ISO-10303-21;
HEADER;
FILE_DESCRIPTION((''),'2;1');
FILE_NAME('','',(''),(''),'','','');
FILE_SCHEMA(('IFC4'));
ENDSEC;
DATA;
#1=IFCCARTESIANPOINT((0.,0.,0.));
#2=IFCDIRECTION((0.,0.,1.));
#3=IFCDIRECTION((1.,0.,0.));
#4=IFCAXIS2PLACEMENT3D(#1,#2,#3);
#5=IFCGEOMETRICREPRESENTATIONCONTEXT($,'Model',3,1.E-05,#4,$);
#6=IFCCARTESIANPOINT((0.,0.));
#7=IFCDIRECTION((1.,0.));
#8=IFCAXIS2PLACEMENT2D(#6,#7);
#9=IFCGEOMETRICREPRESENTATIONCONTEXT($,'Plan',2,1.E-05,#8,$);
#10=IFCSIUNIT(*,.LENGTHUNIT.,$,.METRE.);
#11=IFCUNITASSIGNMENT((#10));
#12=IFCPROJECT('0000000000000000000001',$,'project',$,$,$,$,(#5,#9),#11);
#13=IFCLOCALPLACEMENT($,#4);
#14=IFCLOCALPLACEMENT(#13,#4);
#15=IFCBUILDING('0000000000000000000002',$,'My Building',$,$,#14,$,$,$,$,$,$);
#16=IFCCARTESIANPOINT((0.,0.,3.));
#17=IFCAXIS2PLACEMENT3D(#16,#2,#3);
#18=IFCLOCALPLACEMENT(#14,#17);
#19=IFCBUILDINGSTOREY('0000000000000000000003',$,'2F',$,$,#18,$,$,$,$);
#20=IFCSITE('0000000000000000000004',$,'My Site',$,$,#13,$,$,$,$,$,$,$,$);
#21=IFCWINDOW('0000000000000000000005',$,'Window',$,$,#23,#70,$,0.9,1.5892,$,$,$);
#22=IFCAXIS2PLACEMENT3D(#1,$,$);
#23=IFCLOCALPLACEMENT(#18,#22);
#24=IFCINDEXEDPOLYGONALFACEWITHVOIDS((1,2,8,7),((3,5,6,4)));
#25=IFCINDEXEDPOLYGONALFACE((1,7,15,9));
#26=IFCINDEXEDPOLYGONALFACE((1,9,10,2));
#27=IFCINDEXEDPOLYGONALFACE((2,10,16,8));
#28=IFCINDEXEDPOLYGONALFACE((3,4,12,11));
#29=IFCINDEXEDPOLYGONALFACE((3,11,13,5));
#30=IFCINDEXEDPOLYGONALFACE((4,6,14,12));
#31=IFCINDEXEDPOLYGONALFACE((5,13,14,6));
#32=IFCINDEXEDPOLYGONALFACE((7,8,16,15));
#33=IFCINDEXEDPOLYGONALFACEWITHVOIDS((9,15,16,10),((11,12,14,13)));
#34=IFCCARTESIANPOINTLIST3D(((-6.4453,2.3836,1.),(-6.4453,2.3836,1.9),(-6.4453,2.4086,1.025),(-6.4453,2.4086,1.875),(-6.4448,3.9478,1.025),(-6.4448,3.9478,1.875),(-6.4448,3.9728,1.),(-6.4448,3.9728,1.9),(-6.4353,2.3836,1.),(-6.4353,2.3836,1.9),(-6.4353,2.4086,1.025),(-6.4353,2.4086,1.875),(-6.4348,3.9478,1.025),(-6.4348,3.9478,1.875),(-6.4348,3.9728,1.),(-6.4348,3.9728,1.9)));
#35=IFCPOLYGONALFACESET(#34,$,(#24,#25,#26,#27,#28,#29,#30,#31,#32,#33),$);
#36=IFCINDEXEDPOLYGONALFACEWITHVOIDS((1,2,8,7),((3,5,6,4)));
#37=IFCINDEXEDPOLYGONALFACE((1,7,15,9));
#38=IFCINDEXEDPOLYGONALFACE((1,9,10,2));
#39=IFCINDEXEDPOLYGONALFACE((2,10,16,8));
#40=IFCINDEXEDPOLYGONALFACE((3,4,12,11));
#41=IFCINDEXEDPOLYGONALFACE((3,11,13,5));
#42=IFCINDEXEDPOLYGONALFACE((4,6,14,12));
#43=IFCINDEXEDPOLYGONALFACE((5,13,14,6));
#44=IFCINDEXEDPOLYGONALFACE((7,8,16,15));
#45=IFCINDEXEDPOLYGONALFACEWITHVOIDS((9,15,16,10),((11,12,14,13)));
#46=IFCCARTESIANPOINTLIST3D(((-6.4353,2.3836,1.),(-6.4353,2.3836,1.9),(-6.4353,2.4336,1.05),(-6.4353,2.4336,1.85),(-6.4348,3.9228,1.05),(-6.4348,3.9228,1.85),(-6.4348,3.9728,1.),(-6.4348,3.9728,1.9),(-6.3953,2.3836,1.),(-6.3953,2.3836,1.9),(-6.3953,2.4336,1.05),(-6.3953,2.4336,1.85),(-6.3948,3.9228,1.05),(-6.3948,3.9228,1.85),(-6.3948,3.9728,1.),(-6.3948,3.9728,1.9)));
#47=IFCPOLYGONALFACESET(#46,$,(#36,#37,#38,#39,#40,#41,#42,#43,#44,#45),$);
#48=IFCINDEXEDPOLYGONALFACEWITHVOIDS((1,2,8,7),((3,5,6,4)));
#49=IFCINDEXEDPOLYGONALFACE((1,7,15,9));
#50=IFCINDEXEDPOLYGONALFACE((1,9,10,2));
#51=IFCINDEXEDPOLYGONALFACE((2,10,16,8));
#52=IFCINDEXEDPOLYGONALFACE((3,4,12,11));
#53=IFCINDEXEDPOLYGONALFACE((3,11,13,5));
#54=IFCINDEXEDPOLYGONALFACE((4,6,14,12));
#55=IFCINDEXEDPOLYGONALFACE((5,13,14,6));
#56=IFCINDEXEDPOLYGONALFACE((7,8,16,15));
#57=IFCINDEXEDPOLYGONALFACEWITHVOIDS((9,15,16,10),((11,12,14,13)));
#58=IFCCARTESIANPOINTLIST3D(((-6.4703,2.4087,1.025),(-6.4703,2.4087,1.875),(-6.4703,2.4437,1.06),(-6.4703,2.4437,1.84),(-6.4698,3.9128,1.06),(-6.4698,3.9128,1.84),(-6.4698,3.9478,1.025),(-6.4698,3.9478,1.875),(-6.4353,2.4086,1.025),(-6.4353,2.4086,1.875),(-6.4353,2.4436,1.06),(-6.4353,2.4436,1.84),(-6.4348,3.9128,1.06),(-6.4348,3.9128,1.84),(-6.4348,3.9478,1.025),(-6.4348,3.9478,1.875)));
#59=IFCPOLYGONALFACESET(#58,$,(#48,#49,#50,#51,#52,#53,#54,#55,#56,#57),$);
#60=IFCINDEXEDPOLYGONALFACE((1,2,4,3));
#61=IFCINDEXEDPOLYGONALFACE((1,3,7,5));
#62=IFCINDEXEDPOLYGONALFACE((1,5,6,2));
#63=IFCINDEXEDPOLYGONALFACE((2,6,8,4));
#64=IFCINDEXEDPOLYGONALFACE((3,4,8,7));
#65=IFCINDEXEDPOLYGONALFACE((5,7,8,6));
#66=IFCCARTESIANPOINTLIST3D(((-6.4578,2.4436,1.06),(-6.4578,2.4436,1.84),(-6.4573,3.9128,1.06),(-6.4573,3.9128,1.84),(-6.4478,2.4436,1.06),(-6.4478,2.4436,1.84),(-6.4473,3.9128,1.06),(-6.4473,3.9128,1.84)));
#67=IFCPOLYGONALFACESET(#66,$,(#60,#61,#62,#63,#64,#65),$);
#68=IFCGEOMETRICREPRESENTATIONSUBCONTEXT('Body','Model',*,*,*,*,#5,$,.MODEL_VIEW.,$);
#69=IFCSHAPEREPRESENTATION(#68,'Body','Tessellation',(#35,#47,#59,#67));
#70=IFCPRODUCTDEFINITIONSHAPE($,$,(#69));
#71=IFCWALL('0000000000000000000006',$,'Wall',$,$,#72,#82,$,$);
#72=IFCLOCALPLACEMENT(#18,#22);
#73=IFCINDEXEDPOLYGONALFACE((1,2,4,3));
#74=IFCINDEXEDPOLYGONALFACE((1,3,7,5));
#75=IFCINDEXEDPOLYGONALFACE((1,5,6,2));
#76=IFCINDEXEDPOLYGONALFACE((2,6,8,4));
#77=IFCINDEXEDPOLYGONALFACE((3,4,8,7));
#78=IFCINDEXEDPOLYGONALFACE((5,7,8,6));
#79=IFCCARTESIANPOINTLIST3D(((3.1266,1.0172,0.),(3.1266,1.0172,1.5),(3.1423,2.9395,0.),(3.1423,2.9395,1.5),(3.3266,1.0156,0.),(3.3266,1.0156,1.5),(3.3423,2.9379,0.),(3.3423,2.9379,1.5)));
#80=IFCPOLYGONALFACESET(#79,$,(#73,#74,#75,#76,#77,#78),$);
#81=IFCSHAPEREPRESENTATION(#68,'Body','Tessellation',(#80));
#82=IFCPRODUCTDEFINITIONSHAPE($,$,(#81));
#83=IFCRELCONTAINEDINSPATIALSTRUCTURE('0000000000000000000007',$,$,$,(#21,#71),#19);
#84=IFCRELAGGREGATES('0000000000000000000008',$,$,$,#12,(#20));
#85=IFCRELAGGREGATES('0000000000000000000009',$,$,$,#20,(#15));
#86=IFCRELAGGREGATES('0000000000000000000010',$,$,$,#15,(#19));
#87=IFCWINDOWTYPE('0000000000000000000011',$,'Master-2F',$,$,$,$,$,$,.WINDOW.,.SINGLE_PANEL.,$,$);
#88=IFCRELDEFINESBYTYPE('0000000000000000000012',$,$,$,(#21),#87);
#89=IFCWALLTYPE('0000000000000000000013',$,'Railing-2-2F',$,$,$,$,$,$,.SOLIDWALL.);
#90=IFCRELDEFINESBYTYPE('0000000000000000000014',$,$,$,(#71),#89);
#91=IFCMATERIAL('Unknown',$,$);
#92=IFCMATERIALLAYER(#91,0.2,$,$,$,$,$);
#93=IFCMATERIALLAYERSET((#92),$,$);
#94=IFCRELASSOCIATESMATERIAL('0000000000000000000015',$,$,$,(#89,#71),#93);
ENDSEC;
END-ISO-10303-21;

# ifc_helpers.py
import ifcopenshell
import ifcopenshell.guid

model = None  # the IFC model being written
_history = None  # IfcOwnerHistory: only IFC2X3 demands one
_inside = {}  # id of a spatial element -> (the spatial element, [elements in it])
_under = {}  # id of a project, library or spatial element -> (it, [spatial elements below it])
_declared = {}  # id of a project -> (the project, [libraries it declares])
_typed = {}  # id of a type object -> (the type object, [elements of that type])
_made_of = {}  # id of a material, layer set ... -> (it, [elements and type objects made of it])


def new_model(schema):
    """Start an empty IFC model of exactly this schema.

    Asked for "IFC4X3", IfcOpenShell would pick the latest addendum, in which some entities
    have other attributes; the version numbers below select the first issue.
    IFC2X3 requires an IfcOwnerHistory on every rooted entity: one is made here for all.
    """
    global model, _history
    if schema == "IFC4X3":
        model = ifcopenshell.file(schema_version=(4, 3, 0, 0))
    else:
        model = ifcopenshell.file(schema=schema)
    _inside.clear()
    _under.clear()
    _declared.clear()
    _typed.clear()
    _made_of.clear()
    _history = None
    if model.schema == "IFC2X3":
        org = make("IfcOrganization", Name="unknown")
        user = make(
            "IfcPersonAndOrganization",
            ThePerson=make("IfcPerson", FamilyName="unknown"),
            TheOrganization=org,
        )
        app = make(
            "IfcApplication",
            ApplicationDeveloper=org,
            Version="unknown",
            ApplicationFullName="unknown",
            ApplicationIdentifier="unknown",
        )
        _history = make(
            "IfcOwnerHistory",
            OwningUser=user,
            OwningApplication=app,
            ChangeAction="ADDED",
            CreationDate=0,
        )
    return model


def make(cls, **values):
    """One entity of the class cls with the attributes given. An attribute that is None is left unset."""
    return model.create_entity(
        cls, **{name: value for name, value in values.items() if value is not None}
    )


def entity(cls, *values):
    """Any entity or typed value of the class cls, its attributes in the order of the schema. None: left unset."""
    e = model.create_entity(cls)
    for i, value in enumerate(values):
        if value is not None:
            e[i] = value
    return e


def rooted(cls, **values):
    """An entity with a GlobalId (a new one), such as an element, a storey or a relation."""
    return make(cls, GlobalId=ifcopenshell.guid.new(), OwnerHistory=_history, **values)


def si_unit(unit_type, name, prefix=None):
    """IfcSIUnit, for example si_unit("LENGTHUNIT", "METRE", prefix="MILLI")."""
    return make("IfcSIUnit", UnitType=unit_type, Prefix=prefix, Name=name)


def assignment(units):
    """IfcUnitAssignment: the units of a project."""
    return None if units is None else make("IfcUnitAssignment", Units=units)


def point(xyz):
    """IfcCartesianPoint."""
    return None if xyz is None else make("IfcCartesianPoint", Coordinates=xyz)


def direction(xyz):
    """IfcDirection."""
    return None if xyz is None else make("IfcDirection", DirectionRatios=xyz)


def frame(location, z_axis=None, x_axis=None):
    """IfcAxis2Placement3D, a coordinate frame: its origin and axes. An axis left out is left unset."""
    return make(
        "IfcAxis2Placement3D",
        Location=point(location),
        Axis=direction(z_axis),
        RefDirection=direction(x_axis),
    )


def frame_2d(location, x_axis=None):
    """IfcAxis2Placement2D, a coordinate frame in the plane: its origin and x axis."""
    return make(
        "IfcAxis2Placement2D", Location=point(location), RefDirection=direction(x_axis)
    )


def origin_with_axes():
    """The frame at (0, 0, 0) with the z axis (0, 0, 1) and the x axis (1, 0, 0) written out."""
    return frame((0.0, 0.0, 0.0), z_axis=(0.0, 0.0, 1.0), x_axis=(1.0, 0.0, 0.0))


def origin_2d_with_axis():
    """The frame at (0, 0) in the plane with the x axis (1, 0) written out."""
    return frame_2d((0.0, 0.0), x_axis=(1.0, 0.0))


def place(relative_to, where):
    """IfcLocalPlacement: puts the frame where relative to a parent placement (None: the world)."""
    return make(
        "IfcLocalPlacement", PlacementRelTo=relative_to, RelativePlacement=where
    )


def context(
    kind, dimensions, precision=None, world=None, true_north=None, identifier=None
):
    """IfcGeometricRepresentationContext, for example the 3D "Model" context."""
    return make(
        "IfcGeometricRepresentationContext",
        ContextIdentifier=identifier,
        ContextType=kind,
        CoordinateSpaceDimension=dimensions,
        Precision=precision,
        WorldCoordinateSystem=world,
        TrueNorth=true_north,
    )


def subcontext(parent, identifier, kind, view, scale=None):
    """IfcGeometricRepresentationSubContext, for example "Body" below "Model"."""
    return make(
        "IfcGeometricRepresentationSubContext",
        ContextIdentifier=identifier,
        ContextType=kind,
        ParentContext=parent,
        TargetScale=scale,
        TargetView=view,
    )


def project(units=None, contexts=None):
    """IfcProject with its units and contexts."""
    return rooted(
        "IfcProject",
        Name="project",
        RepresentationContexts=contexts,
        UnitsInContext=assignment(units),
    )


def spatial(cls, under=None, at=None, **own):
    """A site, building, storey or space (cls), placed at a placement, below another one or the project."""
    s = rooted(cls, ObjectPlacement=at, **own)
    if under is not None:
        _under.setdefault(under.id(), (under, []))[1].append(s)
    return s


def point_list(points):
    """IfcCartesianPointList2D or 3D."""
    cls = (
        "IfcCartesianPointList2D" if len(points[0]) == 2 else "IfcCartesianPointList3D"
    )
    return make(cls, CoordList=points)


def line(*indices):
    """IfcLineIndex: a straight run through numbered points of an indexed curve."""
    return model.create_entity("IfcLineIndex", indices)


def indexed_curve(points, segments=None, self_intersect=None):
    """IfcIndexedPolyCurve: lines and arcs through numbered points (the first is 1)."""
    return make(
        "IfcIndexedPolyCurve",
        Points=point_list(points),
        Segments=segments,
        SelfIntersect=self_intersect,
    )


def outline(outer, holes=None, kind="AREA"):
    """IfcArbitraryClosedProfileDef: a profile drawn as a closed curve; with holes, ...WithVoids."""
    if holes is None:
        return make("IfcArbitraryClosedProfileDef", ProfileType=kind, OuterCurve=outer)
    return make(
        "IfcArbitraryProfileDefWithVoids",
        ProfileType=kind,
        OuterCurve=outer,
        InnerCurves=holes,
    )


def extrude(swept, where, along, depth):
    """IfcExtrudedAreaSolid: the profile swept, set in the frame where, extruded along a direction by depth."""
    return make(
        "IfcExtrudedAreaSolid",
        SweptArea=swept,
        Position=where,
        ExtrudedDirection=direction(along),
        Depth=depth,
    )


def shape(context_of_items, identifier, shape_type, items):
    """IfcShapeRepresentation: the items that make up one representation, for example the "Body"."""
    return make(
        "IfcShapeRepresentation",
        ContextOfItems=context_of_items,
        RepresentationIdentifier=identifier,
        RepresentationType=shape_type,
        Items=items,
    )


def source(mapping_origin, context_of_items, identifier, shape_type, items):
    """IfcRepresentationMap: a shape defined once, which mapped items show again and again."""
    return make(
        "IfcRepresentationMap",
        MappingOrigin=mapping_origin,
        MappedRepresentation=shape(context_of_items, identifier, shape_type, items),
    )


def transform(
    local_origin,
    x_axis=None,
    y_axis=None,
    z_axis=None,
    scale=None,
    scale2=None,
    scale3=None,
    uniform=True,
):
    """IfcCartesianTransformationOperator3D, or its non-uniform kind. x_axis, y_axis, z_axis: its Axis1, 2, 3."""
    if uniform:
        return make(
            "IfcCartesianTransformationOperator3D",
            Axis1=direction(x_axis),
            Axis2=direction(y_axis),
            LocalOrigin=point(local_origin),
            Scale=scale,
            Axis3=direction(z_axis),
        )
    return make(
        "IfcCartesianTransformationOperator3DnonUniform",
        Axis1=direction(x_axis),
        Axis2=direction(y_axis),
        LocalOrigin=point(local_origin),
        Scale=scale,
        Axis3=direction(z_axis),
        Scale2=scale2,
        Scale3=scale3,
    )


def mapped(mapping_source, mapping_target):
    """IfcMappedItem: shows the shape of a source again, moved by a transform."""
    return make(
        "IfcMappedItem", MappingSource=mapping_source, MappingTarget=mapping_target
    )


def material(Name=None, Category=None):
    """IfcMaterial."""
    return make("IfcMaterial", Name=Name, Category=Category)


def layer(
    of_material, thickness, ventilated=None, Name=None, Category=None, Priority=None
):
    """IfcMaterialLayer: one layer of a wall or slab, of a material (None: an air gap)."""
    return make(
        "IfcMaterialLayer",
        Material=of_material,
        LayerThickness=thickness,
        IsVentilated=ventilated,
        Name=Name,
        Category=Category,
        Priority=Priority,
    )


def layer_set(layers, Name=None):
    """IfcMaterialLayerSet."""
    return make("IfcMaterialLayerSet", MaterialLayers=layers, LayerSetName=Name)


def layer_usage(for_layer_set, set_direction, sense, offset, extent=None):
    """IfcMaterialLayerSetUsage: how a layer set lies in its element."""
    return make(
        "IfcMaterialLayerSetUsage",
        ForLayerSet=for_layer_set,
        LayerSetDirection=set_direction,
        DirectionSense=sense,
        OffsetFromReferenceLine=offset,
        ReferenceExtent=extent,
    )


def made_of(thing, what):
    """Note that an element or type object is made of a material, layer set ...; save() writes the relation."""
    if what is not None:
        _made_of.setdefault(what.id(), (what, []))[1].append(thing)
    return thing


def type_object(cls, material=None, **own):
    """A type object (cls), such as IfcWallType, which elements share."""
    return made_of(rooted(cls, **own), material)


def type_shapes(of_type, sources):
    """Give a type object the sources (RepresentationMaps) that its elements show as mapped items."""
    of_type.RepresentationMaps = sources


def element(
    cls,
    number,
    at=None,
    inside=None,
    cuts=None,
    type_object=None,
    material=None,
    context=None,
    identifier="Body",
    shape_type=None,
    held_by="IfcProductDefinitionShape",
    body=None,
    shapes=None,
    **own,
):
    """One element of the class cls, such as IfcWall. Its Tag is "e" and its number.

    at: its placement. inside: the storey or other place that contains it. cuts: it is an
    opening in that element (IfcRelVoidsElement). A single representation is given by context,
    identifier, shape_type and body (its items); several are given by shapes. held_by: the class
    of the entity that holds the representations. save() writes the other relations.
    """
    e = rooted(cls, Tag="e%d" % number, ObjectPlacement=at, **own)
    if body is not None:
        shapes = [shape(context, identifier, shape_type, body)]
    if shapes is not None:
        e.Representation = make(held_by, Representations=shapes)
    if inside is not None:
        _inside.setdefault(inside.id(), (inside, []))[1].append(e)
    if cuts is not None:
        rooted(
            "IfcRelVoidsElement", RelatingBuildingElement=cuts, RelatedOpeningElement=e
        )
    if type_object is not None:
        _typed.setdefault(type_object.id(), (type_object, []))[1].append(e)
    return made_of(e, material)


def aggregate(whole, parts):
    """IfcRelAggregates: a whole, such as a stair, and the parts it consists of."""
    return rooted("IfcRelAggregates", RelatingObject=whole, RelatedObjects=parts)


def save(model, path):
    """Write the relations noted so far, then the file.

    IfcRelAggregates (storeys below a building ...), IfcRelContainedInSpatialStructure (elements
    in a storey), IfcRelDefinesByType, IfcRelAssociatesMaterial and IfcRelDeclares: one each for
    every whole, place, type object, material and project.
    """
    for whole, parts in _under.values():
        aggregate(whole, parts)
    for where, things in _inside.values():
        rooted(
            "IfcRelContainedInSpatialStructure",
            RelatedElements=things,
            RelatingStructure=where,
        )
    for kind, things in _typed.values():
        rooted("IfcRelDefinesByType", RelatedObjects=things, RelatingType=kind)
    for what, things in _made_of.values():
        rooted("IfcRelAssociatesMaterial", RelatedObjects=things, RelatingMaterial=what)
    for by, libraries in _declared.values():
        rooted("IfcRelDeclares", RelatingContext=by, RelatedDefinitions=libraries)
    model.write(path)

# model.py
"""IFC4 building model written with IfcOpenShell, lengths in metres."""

from ifc_helpers import new_model, entity, si_unit, frame, origin_with_axes, origin_2d_with_axis, place, context, subcontext, project, spatial, line, indexed_curve, outline, extrude, shape, source, transform, mapped, material, layer, layer_set, layer_usage, type_object, type_shapes, element, save


model = new_model("IFC4")

# Units and contexts
model_context = context("Model", 3, precision=1e-05, world=origin_with_axes())
plan_context = context("Plan", 2, precision=1e-05, world=origin_2d_with_axis())
body_context_1 = subcontext(model_context, "Body", "Model", "MODEL_VIEW")
body_context_2 = subcontext(plan_context, "Body", "Plan", "PLAN_VIEW")
ifc_project = project(units=[si_unit("LENGTHUNIT", "METRE")], contexts=[model_context, plan_context])

# Site, building, storey
site_placement = place(None, origin_with_axes())
site = spatial("IfcSite", under=ifc_project, at=site_placement, Name="My Site")
building_placement = place(site_placement, origin_with_axes())
building = spatial("IfcBuilding", under=site, at=building_placement, Name="My Building")
storey_placement = place(building_placement, frame((0.0, 0.0, 3.0), z_axis=(0.0, 0.0, 1.0), x_axis=(1.0, 0.0, 0.0)))
storey = spatial("IfcBuildingStorey", under=building, at=storey_placement, Name="2F")

# Shared definitions
ifc_material = material(Name="Unknown")

# Window
window_type_1 = type_object("IfcWindowType", Name="Master-2F", PartitioningType="SINGLE_PANEL", PredefinedType="WINDOW")
shared_shape_1 = source(origin_with_axes(), body_context_1, "Body", "SweptSolid", [
    extrude(outline(indexed_curve([(0.0, 0.0), (1.5892, 0.0), (1.5892, 0.9), (0.0, 0.9)], segments=[line(1, 2, 3, 4, 1)]), holes=[indexed_curve([(0.025, 0.025), (1.5642, 0.025), (1.5642, 0.875), (0.025, 0.875)], segments=[line(1, 2, 3, 4, 1)])]), frame((0.0, 0.09, 0.0), z_axis=(0.0, -1.0, 0.0), x_axis=(1.0, 0.0, 0.0)), (0.0, 0.0, -1.0), 0.01),
    extrude(outline(indexed_curve([(0.0, 0.0), (1.5892, 0.0), (1.5892, 0.9), (0.0, 0.9)], segments=[line(1, 2, 3, 4, 1)]), holes=[indexed_curve([(0.05, 0.05), (1.5392, 0.05), (1.5392, 0.85), (0.05, 0.85)], segments=[line(1, 2, 3, 4, 1)])]), frame((0.0, 0.05, 0.0), z_axis=(0.0, -1.0, 0.0), x_axis=(1.0, 0.0, 0.0)), (0.0, 0.0, -1.0), 0.04),
    extrude(outline(indexed_curve([(0.0, 0.0), (1.5392, 0.0), (1.5392, 0.85), (0.0, 0.85)], segments=[line(1, 2, 3, 4, 1)]), holes=[indexed_curve([(0.035, 0.035), (1.5042, 0.035), (1.5042, 0.815), (0.035, 0.815)], segments=[line(1, 2, 3, 4, 1)])]), frame((0.025, 0.09, 0.025), z_axis=(0.0, -1.0, 0.0), x_axis=(1.0, 0.0, 0.0)), (0.0, 0.0, -1.0), 0.035),
    extrude(outline(indexed_curve([(0.035, 0.035), (1.5042, 0.035), (1.5042, 0.815), (0.035, 0.815)], segments=[line(1, 2, 3, 4, 1)])), frame((0.025, 0.1025, 0.025), z_axis=(0.0, -1.0, 0.0), x_axis=(1.0, 0.0, 0.0)), (0.0, 0.0, -1.0), 0.01),
])
shared_shape_2 = source(origin_with_axes(), body_context_2, "Body", "Curve2D", [
    entity("IfcIndexedPolyCurve", entity("IfcCartesianPointList2D", [[0.05, 0.05], [1.5392, 0.05]])),
    entity("IfcIndexedPolyCurve", entity("IfcCartesianPointList2D", [[0.0, 0.1], [0.025, 0.1], [0.025, 0.09], [0.05, 0.09], [0.05, 0.05], [0.0, 0.05]]), [entity("IfcLineIndex", [1, 2, 3, 4, 5, 6, 1])]),
    entity("IfcIndexedPolyCurve", entity("IfcCartesianPointList2D", [[1.5892, 0.1], [1.5642, 0.1], [1.5642, 0.09], [1.5392, 0.09], [1.5392, 0.05], [1.5892, 0.05]]), [entity("IfcLineIndex", [1, 2, 3, 4, 5, 6, 1])]),
    entity("IfcIndexedPolyCurve", entity("IfcCartesianPointList2D", [[0.025, 0.09], [0.06, 0.09], [0.06, 0.125], [0.025, 0.125]]), [entity("IfcLineIndex", [1, 2, 3, 4, 1])]),
    entity("IfcIndexedPolyCurve", entity("IfcCartesianPointList2D", [[1.5642, 0.09], [1.5292, 0.09], [1.5292, 0.125], [1.5642, 0.125]]), [entity("IfcLineIndex", [1, 2, 3, 4, 1])]),
    entity("IfcIndexedPolyCurve", entity("IfcCartesianPointList2D", [[0.06, 0.09], [1.5292, 0.09]])),
    entity("IfcIndexedPolyCurve", entity("IfcCartesianPointList2D", [[0.06, 0.125], [1.5292, 0.125]])),
    entity("IfcIndexedPolyCurve", entity("IfcCartesianPointList2D", [[0.06, 0.1075], [1.5292, 0.1075]])),
])
type_shapes(window_type_1, [shared_shape_1, shared_shape_2])
placement_1 = place(storey_placement, frame((-6.5425, 11.0718, 0.0), z_axis=(0.0, 0.0, 1.0), x_axis=(-0.00033, -1.0, 0.0)))
placement_2 = place(placement_1, frame((8.6881, 0.2, 1.0), z_axis=(0.0, 0.0, 1.0), x_axis=(-1.0, 0.0, 0.0)))
window_1_placement = place(placement_2, frame((0.0, 0.0, 0.0), z_axis=(0.0, 0.0, 1.0), x_axis=(1.0, 0.0, 0.0)))
element("IfcWindow", 1, at=window_1_placement, inside=storey, type_object=window_type_1, Name="Window", OverallHeight=0.9, OverallWidth=1.5892, shapes=[
    shape(body_context_1, "Body", "MappedRepresentation", [mapped(shared_shape_1, transform((0.0, 0.0, 0.0), x_axis=(1.0, 0.0, 0.0), y_axis=(0.0, 1.0, 0.0), z_axis=(0.0, 0.0, 1.0), scale=1.0))]),
    shape(body_context_2, "Body", "MappedRepresentation", [mapped(shared_shape_2, transform((0.0, 0.0, 0.0), x_axis=(1.0, 0.0, 0.0), y_axis=(0.0, 1.0, 0.0), z_axis=(0.0, 0.0, 1.0), scale=1.0))]),
])

# Wall
ifc_layer_1 = layer(ifc_material, 0.2)
ifc_layer_set_1 = layer_set([ifc_layer_1])
ifc_layer_usage_1 = layer_usage(ifc_layer_set_1, "AXIS2", "POSITIVE", 0.0)
wall_type_1 = type_object("IfcWallType", Name="Railing-2-2F", PredefinedType="SOLIDWALL", material=ifc_layer_set_1)
wall_1_placement = place(storey_placement, frame((3.1423, 2.9395, 0.0), z_axis=(0.0, 0.0, 1.0), x_axis=(-0.008162, -0.999967, 0.0)))
element("IfcWall", 2, at=wall_1_placement, inside=storey, type_object=wall_type_1, material=ifc_layer_usage_1, Name="Wall", context=body_context_1, shape_type="SweptSolid", body=[
    extrude(outline(indexed_curve([(0.0, 0.0), (0.0, 0.2), (1.9223, 0.2), (1.9223, 0.0)], segments=[line(1, 2, 3, 4, 1)])), origin_with_axes(), (0.0, 0.0, 1.0), 1.5),
])

save(model, "model.ifc")
